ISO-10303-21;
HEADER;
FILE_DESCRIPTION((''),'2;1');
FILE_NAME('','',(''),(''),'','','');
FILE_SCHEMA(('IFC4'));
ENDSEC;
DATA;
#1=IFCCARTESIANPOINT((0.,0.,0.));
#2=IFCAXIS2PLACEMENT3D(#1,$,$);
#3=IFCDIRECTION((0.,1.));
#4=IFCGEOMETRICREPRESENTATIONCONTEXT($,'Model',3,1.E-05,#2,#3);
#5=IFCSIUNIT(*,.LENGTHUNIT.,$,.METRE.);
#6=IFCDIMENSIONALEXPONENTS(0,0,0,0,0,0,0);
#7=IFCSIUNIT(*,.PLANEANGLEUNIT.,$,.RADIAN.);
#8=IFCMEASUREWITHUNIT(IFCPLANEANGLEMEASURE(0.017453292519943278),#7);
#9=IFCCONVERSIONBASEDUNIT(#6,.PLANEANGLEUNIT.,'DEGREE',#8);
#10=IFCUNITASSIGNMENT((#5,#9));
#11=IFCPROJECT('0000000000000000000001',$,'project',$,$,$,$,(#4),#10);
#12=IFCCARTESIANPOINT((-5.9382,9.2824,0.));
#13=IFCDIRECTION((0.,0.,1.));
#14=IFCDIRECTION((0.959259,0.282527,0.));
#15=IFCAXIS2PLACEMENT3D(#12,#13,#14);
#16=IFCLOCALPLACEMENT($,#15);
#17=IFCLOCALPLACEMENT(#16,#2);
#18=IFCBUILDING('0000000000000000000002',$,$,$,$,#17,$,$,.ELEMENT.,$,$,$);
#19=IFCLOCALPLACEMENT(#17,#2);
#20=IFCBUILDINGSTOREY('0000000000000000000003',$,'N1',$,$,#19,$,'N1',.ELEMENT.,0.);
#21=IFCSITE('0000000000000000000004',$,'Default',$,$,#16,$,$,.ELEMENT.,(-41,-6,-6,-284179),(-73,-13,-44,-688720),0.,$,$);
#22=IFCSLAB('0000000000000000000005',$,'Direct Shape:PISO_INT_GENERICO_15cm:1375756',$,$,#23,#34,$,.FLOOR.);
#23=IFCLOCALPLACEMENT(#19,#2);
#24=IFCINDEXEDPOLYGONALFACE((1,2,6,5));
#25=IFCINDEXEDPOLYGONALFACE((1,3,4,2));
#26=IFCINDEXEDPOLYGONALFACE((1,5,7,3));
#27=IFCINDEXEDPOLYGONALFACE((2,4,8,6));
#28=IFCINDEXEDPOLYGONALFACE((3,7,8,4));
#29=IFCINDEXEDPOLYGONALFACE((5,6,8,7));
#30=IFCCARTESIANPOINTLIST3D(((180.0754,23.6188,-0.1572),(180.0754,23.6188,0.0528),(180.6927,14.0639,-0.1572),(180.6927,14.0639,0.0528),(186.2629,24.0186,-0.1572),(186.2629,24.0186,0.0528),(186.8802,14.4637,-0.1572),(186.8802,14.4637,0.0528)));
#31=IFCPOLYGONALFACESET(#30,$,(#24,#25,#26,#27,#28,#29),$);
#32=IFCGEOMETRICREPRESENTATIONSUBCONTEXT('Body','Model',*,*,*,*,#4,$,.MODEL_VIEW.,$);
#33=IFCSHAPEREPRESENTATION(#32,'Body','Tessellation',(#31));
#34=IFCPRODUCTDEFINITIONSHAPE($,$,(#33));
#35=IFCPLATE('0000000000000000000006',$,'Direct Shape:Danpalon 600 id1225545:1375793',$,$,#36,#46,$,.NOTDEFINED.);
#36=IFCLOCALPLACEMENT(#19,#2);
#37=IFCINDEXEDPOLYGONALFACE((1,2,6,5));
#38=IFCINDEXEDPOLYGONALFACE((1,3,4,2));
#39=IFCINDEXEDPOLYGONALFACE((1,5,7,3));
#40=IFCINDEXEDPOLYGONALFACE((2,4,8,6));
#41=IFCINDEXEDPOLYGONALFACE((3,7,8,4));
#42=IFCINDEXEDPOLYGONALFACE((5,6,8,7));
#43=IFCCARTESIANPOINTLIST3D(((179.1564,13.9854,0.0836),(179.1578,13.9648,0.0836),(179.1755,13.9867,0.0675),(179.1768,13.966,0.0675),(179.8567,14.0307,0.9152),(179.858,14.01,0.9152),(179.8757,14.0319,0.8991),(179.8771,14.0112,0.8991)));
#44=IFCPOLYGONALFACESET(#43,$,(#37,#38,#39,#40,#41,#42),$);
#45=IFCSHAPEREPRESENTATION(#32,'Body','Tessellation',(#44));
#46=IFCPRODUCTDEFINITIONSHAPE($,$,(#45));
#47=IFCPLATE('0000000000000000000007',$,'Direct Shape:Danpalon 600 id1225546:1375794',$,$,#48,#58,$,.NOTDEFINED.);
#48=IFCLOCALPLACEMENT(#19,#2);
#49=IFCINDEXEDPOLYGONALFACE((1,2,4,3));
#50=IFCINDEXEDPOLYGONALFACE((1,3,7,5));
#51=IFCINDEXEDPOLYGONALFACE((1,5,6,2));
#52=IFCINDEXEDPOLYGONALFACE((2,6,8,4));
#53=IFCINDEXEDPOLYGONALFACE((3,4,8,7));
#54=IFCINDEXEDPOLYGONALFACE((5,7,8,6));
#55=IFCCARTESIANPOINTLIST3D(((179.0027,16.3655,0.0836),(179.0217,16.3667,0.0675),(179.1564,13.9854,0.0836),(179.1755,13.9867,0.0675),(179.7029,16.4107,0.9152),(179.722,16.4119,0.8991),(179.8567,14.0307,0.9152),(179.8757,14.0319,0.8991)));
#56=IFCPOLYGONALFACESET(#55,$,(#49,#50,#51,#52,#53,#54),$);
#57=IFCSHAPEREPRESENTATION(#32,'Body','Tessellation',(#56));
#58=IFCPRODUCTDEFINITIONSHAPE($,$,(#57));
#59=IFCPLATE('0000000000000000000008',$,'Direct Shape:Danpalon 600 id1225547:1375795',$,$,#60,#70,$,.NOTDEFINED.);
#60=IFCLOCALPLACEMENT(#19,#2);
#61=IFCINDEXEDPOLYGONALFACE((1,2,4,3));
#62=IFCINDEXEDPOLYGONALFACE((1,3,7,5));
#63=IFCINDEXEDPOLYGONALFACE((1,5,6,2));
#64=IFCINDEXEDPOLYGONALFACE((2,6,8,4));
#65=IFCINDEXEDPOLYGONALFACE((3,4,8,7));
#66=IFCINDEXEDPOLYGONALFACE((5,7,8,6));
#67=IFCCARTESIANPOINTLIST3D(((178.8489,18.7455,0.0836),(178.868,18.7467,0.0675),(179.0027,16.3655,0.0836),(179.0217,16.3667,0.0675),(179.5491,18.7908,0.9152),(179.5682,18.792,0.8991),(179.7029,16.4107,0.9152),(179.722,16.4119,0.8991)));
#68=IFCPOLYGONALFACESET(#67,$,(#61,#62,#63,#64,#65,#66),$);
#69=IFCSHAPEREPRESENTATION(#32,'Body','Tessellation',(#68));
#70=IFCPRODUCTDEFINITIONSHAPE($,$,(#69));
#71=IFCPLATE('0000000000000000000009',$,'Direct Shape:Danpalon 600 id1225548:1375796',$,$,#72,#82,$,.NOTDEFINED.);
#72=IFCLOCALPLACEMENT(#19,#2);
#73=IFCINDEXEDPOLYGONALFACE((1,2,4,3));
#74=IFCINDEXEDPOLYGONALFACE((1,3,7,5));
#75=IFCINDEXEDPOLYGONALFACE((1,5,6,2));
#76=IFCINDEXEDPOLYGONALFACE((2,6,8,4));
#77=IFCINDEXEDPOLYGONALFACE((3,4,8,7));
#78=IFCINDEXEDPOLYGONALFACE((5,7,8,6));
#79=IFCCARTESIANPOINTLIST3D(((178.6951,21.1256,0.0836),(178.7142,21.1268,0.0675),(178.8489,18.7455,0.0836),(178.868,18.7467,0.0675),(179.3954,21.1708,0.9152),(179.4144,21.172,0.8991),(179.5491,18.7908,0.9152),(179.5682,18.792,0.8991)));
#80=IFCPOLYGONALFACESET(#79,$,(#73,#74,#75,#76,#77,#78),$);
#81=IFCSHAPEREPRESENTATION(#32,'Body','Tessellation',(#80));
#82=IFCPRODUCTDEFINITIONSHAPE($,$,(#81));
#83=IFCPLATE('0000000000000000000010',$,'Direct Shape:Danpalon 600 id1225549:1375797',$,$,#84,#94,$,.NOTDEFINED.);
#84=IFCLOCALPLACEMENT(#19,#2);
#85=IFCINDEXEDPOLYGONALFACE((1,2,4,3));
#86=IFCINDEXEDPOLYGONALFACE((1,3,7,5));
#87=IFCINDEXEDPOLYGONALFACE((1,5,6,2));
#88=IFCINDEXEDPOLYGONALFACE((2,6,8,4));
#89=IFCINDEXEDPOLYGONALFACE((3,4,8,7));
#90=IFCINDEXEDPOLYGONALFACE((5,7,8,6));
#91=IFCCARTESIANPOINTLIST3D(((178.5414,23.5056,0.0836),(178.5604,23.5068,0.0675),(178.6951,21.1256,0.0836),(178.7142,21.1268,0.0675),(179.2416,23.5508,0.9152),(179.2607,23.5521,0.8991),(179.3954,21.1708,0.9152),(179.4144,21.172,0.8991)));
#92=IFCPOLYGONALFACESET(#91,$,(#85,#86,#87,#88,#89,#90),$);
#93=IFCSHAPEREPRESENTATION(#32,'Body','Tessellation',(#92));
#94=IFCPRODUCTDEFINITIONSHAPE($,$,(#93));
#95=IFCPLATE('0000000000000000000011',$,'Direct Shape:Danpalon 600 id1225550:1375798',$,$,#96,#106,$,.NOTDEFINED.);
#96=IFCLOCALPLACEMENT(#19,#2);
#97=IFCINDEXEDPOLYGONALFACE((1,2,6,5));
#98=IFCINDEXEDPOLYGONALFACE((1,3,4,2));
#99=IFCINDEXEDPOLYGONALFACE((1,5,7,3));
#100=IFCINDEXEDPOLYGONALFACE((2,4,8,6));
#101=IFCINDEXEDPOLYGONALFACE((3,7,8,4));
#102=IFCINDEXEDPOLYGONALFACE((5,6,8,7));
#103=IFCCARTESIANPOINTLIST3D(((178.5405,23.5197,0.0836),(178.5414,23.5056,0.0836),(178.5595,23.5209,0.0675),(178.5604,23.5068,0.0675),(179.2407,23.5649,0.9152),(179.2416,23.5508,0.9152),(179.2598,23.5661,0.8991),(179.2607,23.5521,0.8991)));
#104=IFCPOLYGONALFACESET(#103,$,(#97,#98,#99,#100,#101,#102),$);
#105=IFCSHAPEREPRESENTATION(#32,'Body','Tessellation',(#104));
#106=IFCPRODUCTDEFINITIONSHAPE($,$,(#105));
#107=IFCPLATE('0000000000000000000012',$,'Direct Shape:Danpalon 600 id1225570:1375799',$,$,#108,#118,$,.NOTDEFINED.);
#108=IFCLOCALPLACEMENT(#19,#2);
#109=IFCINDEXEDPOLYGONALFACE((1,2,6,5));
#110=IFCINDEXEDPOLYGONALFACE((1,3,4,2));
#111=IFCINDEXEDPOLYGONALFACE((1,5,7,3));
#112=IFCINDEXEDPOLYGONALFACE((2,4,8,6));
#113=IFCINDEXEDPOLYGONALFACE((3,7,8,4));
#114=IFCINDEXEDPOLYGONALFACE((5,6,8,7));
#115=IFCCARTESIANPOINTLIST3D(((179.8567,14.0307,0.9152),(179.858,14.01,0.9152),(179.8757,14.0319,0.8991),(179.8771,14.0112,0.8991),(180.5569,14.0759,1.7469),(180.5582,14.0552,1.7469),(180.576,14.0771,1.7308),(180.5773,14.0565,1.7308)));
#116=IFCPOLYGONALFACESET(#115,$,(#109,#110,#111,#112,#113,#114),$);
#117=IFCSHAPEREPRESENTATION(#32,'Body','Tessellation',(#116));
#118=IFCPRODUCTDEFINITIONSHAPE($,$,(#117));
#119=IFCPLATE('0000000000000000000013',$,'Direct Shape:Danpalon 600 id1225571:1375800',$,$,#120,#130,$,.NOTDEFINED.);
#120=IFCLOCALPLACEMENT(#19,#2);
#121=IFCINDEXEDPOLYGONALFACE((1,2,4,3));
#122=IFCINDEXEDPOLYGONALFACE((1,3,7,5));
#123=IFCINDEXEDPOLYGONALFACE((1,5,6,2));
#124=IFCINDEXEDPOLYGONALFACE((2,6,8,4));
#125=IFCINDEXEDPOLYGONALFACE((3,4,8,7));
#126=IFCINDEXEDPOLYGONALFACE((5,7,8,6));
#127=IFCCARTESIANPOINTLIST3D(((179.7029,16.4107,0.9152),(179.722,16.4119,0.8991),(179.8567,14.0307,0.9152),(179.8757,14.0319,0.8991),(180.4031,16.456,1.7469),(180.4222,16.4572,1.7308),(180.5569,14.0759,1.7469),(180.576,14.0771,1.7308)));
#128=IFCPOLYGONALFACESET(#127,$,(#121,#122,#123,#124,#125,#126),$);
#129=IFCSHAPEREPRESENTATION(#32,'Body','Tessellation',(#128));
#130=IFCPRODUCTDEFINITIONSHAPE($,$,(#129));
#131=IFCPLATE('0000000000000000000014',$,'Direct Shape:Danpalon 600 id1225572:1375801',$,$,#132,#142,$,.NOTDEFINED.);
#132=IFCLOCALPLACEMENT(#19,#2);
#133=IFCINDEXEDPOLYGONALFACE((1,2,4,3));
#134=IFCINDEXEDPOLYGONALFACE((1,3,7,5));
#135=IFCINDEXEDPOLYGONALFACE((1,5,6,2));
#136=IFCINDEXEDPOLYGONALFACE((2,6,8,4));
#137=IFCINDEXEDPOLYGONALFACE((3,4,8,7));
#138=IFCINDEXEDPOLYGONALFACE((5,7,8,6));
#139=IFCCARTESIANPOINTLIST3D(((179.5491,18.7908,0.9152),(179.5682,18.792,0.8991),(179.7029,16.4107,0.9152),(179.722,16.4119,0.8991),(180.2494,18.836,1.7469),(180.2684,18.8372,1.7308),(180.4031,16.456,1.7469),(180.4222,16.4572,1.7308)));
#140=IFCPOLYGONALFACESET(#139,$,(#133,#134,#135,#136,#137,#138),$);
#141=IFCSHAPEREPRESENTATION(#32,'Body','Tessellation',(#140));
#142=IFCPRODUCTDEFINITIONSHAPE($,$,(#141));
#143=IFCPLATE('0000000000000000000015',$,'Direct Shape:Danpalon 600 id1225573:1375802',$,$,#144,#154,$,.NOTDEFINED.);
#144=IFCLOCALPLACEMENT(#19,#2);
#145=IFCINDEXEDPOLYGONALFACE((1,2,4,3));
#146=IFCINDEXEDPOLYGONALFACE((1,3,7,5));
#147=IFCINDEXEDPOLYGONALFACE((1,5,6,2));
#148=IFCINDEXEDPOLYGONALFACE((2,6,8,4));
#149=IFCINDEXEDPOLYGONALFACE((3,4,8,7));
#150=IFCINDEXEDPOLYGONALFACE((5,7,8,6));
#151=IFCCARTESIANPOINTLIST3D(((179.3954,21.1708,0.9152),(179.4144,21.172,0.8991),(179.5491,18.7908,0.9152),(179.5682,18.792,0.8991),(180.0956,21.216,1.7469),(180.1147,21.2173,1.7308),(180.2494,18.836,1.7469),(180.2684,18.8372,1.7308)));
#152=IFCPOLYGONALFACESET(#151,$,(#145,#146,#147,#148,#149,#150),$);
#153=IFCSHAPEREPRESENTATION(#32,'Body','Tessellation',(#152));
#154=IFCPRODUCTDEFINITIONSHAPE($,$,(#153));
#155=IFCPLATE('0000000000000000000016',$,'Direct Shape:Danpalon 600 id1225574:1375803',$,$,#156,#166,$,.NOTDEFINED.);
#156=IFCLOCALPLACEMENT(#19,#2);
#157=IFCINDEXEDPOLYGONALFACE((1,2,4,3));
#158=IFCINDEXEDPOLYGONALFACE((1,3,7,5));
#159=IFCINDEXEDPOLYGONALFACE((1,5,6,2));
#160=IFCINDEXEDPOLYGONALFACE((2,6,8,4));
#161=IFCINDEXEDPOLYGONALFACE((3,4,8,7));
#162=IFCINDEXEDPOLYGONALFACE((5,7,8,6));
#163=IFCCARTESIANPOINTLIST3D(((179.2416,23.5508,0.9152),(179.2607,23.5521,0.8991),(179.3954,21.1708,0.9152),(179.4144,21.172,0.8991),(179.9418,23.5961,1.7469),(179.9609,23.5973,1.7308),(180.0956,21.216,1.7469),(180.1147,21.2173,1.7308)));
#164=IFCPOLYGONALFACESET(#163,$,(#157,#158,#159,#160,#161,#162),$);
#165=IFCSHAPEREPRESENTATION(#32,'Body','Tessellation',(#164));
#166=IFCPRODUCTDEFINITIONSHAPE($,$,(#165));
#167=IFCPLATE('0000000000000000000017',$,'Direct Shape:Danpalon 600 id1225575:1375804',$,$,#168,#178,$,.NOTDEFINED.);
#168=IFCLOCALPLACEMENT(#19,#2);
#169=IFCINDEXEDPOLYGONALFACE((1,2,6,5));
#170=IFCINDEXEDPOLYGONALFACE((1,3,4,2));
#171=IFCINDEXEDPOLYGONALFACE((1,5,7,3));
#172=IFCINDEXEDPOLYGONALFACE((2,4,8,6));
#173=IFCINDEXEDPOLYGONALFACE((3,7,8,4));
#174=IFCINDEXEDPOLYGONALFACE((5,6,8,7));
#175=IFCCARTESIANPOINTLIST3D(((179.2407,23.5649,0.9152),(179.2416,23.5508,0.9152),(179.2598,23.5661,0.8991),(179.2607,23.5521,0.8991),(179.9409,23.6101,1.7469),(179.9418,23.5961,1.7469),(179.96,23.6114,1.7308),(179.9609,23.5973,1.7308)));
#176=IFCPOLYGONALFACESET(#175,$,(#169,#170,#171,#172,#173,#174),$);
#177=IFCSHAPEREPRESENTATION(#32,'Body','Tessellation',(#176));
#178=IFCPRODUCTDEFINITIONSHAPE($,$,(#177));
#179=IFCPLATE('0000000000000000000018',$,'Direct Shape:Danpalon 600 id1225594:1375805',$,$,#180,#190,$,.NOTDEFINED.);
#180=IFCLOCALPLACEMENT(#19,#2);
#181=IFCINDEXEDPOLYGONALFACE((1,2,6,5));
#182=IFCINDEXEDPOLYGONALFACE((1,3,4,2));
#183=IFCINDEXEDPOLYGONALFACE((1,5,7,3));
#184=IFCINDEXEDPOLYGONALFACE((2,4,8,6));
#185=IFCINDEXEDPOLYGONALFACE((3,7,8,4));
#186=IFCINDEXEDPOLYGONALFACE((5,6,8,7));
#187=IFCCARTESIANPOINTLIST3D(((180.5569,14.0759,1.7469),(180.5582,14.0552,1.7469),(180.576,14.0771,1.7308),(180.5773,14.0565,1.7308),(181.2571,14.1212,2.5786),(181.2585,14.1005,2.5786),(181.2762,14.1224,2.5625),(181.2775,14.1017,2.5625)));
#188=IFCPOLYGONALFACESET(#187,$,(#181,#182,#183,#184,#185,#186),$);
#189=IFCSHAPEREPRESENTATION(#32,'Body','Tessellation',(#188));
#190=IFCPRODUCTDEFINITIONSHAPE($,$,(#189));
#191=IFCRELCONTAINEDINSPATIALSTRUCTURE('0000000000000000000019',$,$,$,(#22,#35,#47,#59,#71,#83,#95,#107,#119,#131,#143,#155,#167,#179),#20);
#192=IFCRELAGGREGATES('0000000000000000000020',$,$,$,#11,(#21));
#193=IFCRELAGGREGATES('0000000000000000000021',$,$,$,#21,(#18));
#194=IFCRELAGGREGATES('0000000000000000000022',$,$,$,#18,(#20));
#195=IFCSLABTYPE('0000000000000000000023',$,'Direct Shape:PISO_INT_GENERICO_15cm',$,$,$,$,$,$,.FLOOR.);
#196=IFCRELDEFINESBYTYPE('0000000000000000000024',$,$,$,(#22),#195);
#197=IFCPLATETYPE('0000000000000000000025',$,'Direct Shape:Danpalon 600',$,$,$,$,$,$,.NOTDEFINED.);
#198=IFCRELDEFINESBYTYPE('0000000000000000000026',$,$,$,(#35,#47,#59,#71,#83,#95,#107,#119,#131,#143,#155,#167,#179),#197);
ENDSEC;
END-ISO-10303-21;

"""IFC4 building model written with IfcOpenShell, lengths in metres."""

from ifc_helpers import new_model, entity, si_unit, converted_unit, direction, frame, frame_2d, origin, place, context, subcontext, project, spatial, rectangle, extrude, type_object, element, save


model = new_model("IFC4")

# Units and contexts
model_context = context("Model", 3, precision=1e-05, world=origin(), true_north=direction((0.0, 1.0)))
body_context = subcontext(model_context, "Body", "Model", "MODEL_VIEW")
ifc_project = project(units=[si_unit("LENGTHUNIT", "METRE"), converted_unit("PLANEANGLEUNIT", "DEGREE", entity("IfcPlaneAngleMeasure", 0.017453292519943278), si_unit("PLANEANGLEUNIT", "RADIAN"), dimensions=[0, 0, 0, 0, 0, 0, 0])], contexts=[model_context])

# Site, building, storey
site_placement = place(None, frame((-5.9382, 9.2824, 0.0), z_axis=(0.0, 0.0, 1.0), x_axis=(0.959259, 0.282527, 0.0)))
site = spatial("IfcSite", under=ifc_project, at=site_placement, Name="Default", CompositionType="ELEMENT", RefLatitude=(-41, -6, -6, -284179), RefLongitude=(-73, -13, -44, -688720), RefElevation=0.0)
building_placement = place(site_placement, origin())
building = spatial("IfcBuilding", under=site, at=building_placement, CompositionType="ELEMENT")
storey_placement = place(building_placement, origin())
storey = spatial("IfcBuildingStorey", under=building, at=storey_placement, Name="N1", LongName="N1", CompositionType="ELEMENT", Elevation=0.0)

# Slab
slab_type = type_object("IfcSlabType", Name="Direct Shape:PISO_INT_GENERICO_15cm", PredefinedType="FLOOR")
slab_placement = place(storey_placement, origin())
element("IfcSlab", 1, at=slab_placement, inside=storey, type_object=slab_type, Name="Direct Shape:PISO_INT_GENERICO_15cm:1375756", PredefinedType="FLOOR", context=body_context, shape_type="SweptSolid", body=[
    extrude(rectangle(XDim=9.5748, YDim=6.2004, at=frame_2d((0.0, 0.0), x_axis=(1.0, 0.0))), frame((183.4778, 19.0413, -0.1572), z_axis=(0.0, 0.0, 1.0), x_axis=(-0.064471, 0.99792, 0.0)), (0.0, 0.0, 1.0), 0.21),
])

# Plates
plate_type = type_object("IfcPlateType", Name="Direct Shape:Danpalon 600", PredefinedType="NOTDEFINED")
plate_1_placement = place(storey_placement, origin())
element("IfcPlate", 2, at=plate_1_placement, inside=storey, type_object=plate_type, Name="Direct Shape:Danpalon 600 id1225545:1375793", PredefinedType="NOTDEFINED", context=body_context, shape_type="SweptSolid", body=[
    extrude(rectangle(XDim=0.025, YDim=0.0207, at=frame_2d((0.0, 0.0), x_axis=(0.0, 1.0))), frame((179.1666, 13.9757, 0.0755), z_axis=(0.643515, 0.041575, 0.764304), x_axis=(-0.064471, 0.99792, 0.0)), (0.0, 0.0, 1.0), 1.0881),
])
plate_2_placement = place(storey_placement, origin())
element("IfcPlate", 3, at=plate_2_placement, inside=storey, type_object=plate_type, Name="Direct Shape:Danpalon 600 id1225546:1375794", PredefinedType="NOTDEFINED", context=body_context, shape_type="SweptSolid", body=[
    extrude(rectangle(XDim=1.0881, YDim=0.025, at=frame_2d((0.0, 0.0), x_axis=(0.0, 1.0))), frame((179.5161, 14.0087, 0.4914), z_axis=(-0.064471, 0.99792, 0.0), x_axis=(-0.762714, -0.049276, 0.644857)), (0.0, 0.0, 1.0), 2.385),
])
plate_3_placement = place(storey_placement, origin())
element("IfcPlate", 4, at=plate_3_placement, inside=storey, type_object=plate_type, Name="Direct Shape:Danpalon 600 id1225547:1375795", PredefinedType="NOTDEFINED", context=body_context, shape_type="SweptSolid", body=[
    extrude(rectangle(XDim=1.0881, YDim=0.025, at=frame_2d((0.0, 0.0), x_axis=(0.0, 1.0))), frame((179.3623, 16.3887, 0.4914), z_axis=(-0.064471, 0.99792, 0.0), x_axis=(-0.762714, -0.049276, 0.644857)), (0.0, 0.0, 1.0), 2.385),
])
plate_4_placement = place(storey_placement, origin())
element("IfcPlate", 5, at=plate_4_placement, inside=storey, type_object=plate_type, Name="Direct Shape:Danpalon 600 id1225548:1375796", PredefinedType="NOTDEFINED", context=body_context, shape_type="SweptSolid", body=[
    extrude(rectangle(XDim=1.0881, YDim=0.025, at=frame_2d((0.0, 0.0), x_axis=(0.0, 1.0))), frame((179.2086, 18.7687, 0.4914), z_axis=(-0.064471, 0.99792, 0.0), x_axis=(-0.762714, -0.049276, 0.644857)), (0.0, 0.0, 1.0), 2.385),
])
plate_5_placement = place(storey_placement, origin())
element("IfcPlate", 6, at=plate_5_placement, inside=storey, type_object=plate_type, Name="Direct Shape:Danpalon 600 id1225549:1375797", PredefinedType="NOTDEFINED", context=body_context, shape_type="SweptSolid", body=[
    extrude(rectangle(XDim=1.0881, YDim=0.025, at=frame_2d((0.0, 0.0), x_axis=(0.0, 1.0))), frame((179.0548, 21.1488, 0.4914), z_axis=(-0.064471, 0.99792, 0.0), x_axis=(-0.762714, -0.049276, 0.644857)), (0.0, 0.0, 1.0), 2.385),
])
plate_6_placement = place(storey_placement, origin())
element("IfcPlate", 7, at=plate_6_placement, inside=storey, type_object=plate_type, Name="Direct Shape:Danpalon 600 id1225550:1375798", PredefinedType="NOTDEFINED", context=body_context, shape_type="SweptSolid", body=[
    extrude(rectangle(XDim=0.025, YDim=0.0141, at=frame_2d((0.0, 0.0), x_axis=(0.0, 1.0))), frame((178.5505, 23.5132, 0.0755), z_axis=(0.643515, 0.041575, 0.764304), x_axis=(0.064471, -0.99792, 0.0)), (0.0, 0.0, 1.0), 1.0881),
])
plate_7_placement = place(storey_placement, origin())
element("IfcPlate", 8, at=plate_7_placement, inside=storey, type_object=plate_type, Name="Direct Shape:Danpalon 600 id1225570:1375799", PredefinedType="NOTDEFINED", context=body_context, shape_type="SweptSolid", body=[
    extrude(rectangle(XDim=0.025, YDim=0.0207, at=frame_2d((0.0, 0.0), x_axis=(0.0, 1.0))), frame((179.8669, 14.021, 0.9072), z_axis=(0.643515, 0.041575, 0.764304), x_axis=(-0.064471, 0.99792, 0.0)), (0.0, 0.0, 1.0), 1.0881),
])
plate_8_placement = place(storey_placement, origin())
element("IfcPlate", 9, at=plate_8_placement, inside=storey, type_object=plate_type, Name="Direct Shape:Danpalon 600 id1225571:1375800", PredefinedType="NOTDEFINED", context=body_context, shape_type="SweptSolid", body=[
    extrude(rectangle(XDim=1.0881, YDim=0.025, at=frame_2d((0.0, 0.0), x_axis=(0.0, 1.0))), frame((180.2163, 14.0539, 1.323), z_axis=(-0.064471, 0.99792, 0.0), x_axis=(-0.762714, -0.049276, 0.644857)), (0.0, 0.0, 1.0), 2.385),
])
plate_9_placement = place(storey_placement, origin())
element("IfcPlate", 10, at=plate_9_placement, inside=storey, type_object=plate_type, Name="Direct Shape:Danpalon 600 id1225572:1375801", PredefinedType="NOTDEFINED", context=body_context, shape_type="SweptSolid", body=[
    extrude(rectangle(XDim=1.0881, YDim=0.025, at=frame_2d((0.0, 0.0), x_axis=(0.0, 1.0))), frame((180.0626, 16.4339, 1.323), z_axis=(-0.064471, 0.99792, 0.0), x_axis=(-0.762714, -0.049276, 0.644857)), (0.0, 0.0, 1.0), 2.385),
])
plate_10_placement = place(storey_placement, origin())
element("IfcPlate", 11, at=plate_10_placement, inside=storey, type_object=plate_type, Name="Direct Shape:Danpalon 600 id1225573:1375802", PredefinedType="NOTDEFINED", context=body_context, shape_type="SweptSolid", body=[
    extrude(rectangle(XDim=1.0881, YDim=0.025, at=frame_2d((0.0, 0.0), x_axis=(0.0, 1.0))), frame((179.9088, 18.814, 1.323), z_axis=(-0.064471, 0.99792, 0.0), x_axis=(-0.762714, -0.049276, 0.644857)), (0.0, 0.0, 1.0), 2.385),
])
plate_11_placement = place(storey_placement, origin())
element("IfcPlate", 12, at=plate_11_placement, inside=storey, type_object=plate_type, Name="Direct Shape:Danpalon 600 id1225574:1375803", PredefinedType="NOTDEFINED", context=body_context, shape_type="SweptSolid", body=[
    extrude(rectangle(XDim=1.0881, YDim=0.025, at=frame_2d((0.0, 0.0), x_axis=(0.0, 1.0))), frame((179.755, 21.194, 1.323), z_axis=(-0.064471, 0.99792, 0.0), x_axis=(-0.762714, -0.049276, 0.644857)), (0.0, 0.0, 1.0), 2.385),
])
plate_12_placement = place(storey_placement, origin())
element("IfcPlate", 13, at=plate_12_placement, inside=storey, type_object=plate_type, Name="Direct Shape:Danpalon 600 id1225575:1375804", PredefinedType="NOTDEFINED", context=body_context, shape_type="SweptSolid", body=[
    extrude(rectangle(XDim=0.025, YDim=0.0141, at=frame_2d((0.0, 0.0), x_axis=(0.0, 1.0))), frame((179.2507, 23.5585, 0.9072), z_axis=(0.643515, 0.041575, 0.764304), x_axis=(0.064471, -0.99792, 0.0)), (0.0, 0.0, 1.0), 1.0881),
])
plate_13_placement = place(storey_placement, origin())
element("IfcPlate", 14, at=plate_13_placement, inside=storey, type_object=plate_type, Name="Direct Shape:Danpalon 600 id1225594:1375805", PredefinedType="NOTDEFINED", context=body_context, shape_type="SweptSolid", body=[
    extrude(rectangle(XDim=0.025, YDim=0.0207, at=frame_2d((0.0, 0.0), x_axis=(0.0, 1.0))), frame((180.5671, 14.0662, 1.7389), z_axis=(0.643515, 0.041575, 0.764304), x_axis=(-0.064471, 0.99792, 0.0)), (0.0, 0.0, 1.0), 1.0881),
])

save(model, "model.ifc")
